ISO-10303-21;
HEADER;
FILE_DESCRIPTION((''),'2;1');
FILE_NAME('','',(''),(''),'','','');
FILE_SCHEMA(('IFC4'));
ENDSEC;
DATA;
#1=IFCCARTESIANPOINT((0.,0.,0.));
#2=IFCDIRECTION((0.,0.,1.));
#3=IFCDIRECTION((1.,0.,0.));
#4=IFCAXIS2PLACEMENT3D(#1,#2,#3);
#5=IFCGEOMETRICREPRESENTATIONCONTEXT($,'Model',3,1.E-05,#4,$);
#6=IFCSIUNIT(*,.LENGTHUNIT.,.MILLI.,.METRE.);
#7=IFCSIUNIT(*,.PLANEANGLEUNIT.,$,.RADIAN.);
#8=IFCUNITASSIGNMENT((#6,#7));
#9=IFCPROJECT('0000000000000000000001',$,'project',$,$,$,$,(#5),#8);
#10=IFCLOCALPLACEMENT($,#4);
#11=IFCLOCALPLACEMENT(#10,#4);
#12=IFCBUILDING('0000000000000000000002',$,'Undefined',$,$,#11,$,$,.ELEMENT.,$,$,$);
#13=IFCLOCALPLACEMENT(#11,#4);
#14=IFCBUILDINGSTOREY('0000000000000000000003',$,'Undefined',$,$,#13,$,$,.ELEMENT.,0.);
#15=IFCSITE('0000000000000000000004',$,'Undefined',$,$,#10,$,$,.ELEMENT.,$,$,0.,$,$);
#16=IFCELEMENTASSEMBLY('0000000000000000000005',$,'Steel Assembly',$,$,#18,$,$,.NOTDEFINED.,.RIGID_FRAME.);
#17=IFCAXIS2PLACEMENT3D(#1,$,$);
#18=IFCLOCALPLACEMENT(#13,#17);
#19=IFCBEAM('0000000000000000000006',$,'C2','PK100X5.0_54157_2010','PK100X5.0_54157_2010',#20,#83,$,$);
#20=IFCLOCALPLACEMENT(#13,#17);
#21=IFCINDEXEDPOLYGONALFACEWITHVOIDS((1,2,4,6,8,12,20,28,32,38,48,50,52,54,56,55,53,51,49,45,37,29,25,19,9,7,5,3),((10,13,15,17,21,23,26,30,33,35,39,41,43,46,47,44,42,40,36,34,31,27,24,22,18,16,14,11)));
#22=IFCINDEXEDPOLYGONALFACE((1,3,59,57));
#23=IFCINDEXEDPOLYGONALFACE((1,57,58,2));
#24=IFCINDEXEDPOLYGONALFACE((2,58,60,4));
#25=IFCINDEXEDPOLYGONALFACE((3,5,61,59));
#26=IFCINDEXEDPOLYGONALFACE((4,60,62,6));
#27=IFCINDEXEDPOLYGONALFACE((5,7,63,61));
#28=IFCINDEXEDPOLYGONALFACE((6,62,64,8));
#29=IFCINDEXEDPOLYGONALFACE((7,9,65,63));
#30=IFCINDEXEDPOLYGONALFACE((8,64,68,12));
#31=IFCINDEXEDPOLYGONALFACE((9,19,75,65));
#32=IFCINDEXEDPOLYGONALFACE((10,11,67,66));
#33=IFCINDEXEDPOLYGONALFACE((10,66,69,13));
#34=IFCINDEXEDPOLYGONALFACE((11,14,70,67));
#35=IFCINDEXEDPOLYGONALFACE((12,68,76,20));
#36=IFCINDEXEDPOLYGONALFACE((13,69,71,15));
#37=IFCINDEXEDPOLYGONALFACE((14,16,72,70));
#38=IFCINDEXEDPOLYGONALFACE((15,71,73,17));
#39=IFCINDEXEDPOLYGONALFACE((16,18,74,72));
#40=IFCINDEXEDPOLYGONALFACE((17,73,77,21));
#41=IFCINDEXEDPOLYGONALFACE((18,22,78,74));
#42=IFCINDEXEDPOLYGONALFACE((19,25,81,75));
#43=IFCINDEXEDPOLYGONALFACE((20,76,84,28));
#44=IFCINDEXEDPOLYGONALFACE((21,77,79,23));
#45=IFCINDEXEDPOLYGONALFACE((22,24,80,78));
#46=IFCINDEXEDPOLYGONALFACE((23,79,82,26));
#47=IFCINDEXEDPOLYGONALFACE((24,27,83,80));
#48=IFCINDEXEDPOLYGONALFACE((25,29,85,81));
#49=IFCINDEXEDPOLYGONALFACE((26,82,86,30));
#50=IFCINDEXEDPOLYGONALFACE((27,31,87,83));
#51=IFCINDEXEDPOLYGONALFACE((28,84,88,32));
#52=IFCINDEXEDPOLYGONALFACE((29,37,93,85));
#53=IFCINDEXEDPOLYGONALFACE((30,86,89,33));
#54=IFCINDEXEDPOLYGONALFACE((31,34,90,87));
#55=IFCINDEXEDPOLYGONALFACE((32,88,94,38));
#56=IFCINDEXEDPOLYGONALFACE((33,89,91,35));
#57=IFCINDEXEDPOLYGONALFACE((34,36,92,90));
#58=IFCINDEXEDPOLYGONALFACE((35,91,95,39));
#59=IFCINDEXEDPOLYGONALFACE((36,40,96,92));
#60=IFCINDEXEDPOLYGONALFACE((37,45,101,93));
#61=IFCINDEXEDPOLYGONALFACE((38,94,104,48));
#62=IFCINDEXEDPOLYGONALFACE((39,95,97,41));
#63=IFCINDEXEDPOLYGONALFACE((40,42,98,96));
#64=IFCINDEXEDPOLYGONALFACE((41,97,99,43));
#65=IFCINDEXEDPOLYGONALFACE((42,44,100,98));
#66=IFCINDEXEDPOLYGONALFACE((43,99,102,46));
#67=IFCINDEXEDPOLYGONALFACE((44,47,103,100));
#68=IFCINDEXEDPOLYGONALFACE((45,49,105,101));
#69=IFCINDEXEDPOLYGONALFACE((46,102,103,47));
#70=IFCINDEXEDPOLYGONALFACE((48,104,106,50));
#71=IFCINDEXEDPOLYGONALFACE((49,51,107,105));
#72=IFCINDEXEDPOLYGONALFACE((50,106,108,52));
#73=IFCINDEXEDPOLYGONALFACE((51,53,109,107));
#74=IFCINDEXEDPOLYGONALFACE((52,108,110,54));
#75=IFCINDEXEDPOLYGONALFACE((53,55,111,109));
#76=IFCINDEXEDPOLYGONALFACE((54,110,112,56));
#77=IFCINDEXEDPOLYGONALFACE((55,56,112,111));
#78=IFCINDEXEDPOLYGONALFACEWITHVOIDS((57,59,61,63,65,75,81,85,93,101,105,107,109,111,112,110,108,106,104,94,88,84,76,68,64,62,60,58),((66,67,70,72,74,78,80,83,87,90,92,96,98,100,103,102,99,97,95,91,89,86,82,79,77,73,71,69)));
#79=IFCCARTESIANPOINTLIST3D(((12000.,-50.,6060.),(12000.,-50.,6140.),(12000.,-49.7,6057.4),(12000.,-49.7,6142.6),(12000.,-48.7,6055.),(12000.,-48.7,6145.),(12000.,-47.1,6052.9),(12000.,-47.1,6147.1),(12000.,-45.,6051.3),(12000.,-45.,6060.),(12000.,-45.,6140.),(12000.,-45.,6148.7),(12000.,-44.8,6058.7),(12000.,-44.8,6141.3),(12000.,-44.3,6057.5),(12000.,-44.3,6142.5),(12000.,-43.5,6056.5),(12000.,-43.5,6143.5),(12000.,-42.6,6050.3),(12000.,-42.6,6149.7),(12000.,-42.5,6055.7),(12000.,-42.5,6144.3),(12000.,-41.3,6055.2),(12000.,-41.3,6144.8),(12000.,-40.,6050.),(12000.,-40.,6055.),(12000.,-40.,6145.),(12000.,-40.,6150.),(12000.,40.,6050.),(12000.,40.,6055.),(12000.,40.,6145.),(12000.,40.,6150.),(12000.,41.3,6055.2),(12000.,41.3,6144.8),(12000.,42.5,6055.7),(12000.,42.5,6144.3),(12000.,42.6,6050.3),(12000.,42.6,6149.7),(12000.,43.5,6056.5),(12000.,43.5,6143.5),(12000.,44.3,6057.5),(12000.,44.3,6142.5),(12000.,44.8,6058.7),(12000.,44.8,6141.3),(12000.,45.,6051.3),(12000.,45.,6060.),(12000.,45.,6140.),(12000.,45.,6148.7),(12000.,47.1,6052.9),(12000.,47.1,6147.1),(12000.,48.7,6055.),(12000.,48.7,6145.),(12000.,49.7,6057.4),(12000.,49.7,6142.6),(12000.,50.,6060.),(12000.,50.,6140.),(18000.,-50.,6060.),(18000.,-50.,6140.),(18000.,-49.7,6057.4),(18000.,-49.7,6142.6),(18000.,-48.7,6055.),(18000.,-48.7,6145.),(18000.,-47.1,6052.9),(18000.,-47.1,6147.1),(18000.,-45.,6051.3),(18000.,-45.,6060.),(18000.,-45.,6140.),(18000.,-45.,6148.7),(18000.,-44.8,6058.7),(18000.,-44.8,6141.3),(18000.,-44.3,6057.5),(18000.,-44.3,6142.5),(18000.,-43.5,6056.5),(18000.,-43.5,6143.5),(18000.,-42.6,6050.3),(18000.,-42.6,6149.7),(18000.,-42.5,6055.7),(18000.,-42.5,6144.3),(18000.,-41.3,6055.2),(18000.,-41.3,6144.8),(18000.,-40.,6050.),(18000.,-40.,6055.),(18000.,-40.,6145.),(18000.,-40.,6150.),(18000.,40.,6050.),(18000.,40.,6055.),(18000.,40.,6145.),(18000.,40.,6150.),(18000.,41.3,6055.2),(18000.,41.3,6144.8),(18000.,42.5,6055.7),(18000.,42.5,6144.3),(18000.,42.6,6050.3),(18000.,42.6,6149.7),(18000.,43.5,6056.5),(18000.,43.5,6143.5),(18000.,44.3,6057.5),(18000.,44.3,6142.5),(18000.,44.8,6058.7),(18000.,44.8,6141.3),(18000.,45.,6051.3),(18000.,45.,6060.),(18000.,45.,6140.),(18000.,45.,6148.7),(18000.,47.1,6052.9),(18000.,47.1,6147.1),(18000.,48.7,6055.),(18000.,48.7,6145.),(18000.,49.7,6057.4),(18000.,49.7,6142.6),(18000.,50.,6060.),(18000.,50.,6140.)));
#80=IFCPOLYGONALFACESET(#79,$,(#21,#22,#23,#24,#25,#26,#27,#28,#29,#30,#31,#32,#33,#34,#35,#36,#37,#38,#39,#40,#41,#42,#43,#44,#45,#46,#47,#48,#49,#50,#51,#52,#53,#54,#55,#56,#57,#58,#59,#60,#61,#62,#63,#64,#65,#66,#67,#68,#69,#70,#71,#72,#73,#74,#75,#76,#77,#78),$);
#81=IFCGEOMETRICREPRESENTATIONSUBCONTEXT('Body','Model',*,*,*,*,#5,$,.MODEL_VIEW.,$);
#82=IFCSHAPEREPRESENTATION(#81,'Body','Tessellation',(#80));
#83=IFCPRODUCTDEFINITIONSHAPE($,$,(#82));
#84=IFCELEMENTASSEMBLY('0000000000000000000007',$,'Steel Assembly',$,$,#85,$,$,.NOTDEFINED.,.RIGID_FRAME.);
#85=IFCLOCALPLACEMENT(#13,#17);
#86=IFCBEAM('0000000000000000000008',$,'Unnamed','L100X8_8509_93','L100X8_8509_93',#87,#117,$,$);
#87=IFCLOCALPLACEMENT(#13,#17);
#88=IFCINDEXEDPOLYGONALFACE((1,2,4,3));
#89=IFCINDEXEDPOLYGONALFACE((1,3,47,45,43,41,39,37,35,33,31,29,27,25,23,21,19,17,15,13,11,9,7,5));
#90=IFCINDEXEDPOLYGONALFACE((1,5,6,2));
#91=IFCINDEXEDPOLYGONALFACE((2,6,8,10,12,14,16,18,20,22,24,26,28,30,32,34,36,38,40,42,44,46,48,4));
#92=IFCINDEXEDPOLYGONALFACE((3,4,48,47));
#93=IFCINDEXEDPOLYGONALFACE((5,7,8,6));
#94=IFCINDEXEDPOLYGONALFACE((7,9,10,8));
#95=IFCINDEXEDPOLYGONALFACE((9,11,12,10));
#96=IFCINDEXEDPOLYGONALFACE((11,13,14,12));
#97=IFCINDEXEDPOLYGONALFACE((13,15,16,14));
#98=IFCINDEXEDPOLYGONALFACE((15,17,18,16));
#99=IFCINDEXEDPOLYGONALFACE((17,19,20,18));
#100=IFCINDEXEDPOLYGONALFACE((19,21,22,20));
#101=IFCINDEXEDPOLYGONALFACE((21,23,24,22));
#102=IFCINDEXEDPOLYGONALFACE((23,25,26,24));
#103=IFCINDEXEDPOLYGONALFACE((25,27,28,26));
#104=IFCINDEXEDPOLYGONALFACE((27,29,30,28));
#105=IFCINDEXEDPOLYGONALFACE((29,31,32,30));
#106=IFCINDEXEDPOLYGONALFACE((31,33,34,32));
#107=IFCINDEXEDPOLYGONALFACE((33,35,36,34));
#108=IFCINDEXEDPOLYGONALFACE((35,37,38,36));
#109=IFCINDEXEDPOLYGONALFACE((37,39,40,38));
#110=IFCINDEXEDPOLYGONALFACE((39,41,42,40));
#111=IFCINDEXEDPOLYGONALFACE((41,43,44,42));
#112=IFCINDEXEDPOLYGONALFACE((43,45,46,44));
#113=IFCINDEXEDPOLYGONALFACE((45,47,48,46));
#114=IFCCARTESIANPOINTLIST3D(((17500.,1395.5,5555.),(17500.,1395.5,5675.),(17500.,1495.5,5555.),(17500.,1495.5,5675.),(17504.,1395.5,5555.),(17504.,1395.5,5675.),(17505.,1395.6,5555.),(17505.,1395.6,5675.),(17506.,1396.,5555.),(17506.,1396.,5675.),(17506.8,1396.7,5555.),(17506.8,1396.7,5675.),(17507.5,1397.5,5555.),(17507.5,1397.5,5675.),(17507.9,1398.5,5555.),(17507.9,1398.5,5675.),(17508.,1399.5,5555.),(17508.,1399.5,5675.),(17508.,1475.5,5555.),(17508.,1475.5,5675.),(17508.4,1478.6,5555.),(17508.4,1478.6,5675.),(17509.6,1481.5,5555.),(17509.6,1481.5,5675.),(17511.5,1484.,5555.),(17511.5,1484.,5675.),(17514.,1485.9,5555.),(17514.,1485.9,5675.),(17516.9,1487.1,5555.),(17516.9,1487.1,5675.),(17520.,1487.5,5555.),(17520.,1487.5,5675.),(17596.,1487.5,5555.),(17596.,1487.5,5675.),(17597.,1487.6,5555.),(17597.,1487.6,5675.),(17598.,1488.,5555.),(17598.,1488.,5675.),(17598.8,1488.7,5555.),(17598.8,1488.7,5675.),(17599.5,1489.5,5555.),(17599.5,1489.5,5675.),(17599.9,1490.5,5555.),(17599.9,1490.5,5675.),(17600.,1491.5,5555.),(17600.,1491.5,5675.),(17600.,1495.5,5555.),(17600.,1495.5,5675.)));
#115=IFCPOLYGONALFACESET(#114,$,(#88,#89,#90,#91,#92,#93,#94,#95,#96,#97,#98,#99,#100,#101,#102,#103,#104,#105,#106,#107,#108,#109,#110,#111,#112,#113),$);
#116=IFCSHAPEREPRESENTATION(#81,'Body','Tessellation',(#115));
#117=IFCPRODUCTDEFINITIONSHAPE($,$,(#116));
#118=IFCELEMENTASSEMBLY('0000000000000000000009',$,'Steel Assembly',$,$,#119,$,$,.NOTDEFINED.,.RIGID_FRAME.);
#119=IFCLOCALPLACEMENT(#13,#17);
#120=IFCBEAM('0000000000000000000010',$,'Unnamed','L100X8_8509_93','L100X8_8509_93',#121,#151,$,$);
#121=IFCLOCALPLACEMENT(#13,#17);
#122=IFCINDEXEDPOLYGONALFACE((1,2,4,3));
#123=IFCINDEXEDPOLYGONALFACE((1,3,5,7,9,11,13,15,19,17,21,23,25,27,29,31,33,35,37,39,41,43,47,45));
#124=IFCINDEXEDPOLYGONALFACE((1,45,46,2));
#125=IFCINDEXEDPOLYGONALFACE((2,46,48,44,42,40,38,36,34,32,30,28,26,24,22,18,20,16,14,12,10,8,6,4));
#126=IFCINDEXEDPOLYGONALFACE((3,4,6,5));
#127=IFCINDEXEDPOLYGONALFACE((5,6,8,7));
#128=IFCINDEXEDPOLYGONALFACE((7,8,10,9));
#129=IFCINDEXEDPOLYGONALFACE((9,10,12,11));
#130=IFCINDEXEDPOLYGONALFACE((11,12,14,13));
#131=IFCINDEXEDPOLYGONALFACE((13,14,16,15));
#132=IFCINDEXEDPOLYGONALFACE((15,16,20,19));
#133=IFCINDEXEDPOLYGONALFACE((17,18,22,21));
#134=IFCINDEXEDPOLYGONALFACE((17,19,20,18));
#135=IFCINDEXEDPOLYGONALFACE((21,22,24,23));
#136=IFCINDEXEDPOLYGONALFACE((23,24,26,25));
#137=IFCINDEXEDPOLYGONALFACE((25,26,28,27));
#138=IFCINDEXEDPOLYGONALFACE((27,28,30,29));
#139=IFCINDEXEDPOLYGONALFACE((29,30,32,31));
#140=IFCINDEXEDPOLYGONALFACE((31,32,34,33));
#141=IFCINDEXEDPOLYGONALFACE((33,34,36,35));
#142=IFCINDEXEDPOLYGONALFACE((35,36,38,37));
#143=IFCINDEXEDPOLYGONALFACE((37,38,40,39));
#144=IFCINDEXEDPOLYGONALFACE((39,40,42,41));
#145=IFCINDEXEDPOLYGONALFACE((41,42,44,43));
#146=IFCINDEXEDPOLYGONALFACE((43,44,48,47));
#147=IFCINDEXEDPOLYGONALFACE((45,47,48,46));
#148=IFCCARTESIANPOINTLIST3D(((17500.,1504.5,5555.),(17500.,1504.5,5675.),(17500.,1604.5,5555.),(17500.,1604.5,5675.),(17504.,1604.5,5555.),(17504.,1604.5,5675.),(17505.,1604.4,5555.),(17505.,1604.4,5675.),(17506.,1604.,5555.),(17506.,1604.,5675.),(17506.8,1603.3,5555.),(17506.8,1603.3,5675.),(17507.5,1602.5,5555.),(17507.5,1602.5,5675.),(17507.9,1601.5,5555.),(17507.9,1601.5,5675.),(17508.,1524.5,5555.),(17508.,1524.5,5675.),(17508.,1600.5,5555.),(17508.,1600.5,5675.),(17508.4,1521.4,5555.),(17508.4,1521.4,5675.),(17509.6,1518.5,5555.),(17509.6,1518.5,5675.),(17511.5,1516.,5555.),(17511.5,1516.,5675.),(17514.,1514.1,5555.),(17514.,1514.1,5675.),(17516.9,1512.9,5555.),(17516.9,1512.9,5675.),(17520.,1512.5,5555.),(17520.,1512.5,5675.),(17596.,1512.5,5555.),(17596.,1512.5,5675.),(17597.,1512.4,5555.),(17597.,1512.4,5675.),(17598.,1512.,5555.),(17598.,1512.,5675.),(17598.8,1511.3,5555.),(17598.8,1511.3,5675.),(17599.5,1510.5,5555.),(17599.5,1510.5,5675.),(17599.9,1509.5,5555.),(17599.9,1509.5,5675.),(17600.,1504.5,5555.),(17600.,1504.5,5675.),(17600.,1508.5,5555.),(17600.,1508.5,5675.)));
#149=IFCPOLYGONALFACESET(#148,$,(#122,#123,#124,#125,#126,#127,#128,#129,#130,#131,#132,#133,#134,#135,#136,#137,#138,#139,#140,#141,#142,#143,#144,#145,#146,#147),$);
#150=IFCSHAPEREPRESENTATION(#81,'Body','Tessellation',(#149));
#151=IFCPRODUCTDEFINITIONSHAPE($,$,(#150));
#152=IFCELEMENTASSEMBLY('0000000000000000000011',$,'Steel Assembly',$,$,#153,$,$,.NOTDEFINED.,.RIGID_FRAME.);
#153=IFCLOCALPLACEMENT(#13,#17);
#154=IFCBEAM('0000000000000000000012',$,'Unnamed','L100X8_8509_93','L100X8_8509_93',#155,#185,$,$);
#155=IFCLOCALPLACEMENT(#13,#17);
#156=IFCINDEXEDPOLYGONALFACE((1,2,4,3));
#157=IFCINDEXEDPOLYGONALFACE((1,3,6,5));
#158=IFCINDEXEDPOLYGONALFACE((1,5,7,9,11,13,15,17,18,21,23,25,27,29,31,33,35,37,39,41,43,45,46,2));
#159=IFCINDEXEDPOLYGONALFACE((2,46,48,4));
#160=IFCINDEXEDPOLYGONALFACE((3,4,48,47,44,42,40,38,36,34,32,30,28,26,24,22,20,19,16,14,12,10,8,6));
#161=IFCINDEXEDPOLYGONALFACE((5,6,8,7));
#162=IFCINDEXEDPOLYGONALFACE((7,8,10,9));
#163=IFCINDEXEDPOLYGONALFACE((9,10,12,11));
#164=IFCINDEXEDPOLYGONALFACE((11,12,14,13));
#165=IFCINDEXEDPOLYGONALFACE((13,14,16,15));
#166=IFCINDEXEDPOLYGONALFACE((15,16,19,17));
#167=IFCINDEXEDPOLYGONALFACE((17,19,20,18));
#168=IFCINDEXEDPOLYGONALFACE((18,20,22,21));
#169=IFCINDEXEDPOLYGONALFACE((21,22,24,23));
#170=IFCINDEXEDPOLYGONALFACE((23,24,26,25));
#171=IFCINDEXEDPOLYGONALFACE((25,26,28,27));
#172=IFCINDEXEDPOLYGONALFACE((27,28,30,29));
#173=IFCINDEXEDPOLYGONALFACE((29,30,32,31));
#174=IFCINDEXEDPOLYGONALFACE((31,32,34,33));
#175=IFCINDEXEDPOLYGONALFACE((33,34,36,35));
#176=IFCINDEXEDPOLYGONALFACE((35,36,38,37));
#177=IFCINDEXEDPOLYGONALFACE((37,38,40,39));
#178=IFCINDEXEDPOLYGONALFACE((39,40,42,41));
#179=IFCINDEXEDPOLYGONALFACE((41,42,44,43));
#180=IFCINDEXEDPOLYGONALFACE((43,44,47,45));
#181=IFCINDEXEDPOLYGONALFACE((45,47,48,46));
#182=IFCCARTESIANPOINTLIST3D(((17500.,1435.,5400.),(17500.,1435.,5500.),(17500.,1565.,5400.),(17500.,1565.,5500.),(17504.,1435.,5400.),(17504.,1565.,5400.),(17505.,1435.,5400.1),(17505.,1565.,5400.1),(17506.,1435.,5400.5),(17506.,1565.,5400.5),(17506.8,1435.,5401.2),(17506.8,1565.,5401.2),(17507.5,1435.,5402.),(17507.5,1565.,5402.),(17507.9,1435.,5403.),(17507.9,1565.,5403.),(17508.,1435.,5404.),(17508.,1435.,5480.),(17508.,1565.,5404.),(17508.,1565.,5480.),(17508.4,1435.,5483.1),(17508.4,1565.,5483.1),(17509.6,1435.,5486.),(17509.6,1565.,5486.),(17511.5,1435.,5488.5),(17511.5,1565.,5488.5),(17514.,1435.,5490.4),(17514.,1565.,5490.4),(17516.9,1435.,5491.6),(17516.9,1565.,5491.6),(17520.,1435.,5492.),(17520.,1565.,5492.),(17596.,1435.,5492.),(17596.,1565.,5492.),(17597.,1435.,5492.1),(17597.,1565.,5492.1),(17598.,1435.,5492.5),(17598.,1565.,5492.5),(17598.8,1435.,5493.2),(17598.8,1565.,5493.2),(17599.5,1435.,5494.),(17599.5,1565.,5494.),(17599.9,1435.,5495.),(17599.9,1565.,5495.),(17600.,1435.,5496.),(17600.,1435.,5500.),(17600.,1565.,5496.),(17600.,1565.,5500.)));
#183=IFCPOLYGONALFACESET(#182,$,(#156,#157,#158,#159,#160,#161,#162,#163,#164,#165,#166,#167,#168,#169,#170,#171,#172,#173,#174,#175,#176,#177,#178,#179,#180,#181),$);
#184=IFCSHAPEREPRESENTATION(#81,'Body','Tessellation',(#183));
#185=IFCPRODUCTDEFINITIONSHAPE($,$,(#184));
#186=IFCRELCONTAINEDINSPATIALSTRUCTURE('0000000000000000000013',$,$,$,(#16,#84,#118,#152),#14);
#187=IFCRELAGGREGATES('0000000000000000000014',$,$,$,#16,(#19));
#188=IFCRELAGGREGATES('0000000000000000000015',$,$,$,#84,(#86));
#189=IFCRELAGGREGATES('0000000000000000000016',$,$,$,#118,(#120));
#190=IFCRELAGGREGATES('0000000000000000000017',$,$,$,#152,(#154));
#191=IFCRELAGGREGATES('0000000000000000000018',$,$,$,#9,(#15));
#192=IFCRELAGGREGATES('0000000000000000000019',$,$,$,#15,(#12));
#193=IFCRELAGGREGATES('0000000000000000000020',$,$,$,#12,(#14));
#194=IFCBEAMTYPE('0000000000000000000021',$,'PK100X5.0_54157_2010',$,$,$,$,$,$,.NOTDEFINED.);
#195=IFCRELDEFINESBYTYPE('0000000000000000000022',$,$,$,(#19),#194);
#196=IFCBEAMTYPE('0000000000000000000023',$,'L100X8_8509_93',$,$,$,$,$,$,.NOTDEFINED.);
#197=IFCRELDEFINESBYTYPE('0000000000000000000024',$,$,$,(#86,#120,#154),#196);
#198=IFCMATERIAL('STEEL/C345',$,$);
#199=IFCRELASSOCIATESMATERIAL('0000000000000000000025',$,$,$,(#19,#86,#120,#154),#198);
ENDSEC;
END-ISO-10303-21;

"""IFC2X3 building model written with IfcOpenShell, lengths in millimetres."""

from ifc_helpers import new_model, si_unit, frame, origin_with_axes, origin_2d_with_axis, place, context, subcontext, project, spatial, hollow_rectangle, l_section, extrude, material, type_object, element, aggregate, save


model = new_model("IFC2X3")

# Units and contexts
model_context = context("Model", 3, precision=1e-05, world=origin_with_axes())
body_context = subcontext(model_context, "Body", "Model", "MODEL_VIEW")
ifc_project = project(units=[si_unit("LENGTHUNIT", "METRE", prefix="MILLI"), si_unit("PLANEANGLEUNIT", "RADIAN")], contexts=[model_context])

# Site, building, storey
site_placement = place(None, origin_with_axes())
site = spatial("IfcSite", under=ifc_project, at=site_placement, Name="Undefined", CompositionType="ELEMENT", RefElevation=0.0)
building_placement = place(site_placement, origin_with_axes())
building = spatial("IfcBuilding", under=site, at=building_placement, Name="Undefined", CompositionType="ELEMENT")
storey_placement = place(building_placement, origin_with_axes())
storey = spatial("IfcBuildingStorey", under=building, at=storey_placement, Name="Undefined", CompositionType="ELEMENT", Elevation=0.0)

# Element assemblies, beams
assembly_1_placement = place(storey_placement, origin_with_axes())
assembly_1 = element("IfcElementAssembly", 1, at=assembly_1_placement, inside=storey, Name="Steel Assembly", AssemblyPlace="NOTDEFINED", PredefinedType="RIGID_FRAME")
ifc_material = material(Name="STEEL/C345")
beam_type_1 = type_object("IfcBeamType", Name="PK100X5.0_54157_2010", PredefinedType="NOTDEFINED")
beam_1_placement = place(assembly_1_placement, frame((18000.0, 0.0, 6100.0), z_axis=(0.0, 0.0, 1.0), x_axis=(-1.0, 0.0, 0.0)))
beam_1 = element("IfcBeam", 2, at=beam_1_placement, type_object=beam_type_1, material=ifc_material, Name="C2", Description="PK100X5.0_54157_2010", ObjectType="PK100X5.0_54157_2010", context=body_context, shape_type="SweptSolid", body=[
    extrude(hollow_rectangle(XDim=100.0, YDim=100.0, WallThickness=5.0, InnerFilletRadius=5.0, OuterFilletRadius=10.0, at=origin_2d_with_axis()), frame((6000.0, 0.0, 0.0), z_axis=(-1.0, 0.0, 0.0), x_axis=(0.0, -1.0, 0.0)), (0.0, 0.0, 1.0), 6000.0),
])
aggregate(assembly_1, [beam_1])
assembly_2_placement = place(storey_placement, origin_with_axes())
assembly_2 = element("IfcElementAssembly", 3, at=assembly_2_placement, inside=storey, Name="Steel Assembly", AssemblyPlace="NOTDEFINED", PredefinedType="RIGID_FRAME")
beam_type_2 = type_object("IfcBeamType", Name="L100X8_8509_93", PredefinedType="NOTDEFINED")
beam_2_placement = place(assembly_2_placement, frame((17550.0, 1445.5, 5675.0), z_axis=(1.0, 0.0, 0.0), x_axis=(0.0, 0.0, -1.0)))
beam_2 = element("IfcBeam", 4, at=beam_2_placement, type_object=beam_type_2, material=ifc_material, Name="Unnamed", Description="L100X8_8509_93", ObjectType="L100X8_8509_93", context=body_context, shape_type="SweptSolid", body=[
    extrude(l_section(Depth=100.0, Width=100.0, Thickness=8.0, FilletRadius=12.0, EdgeRadius=4.0, at=origin_2d_with_axis()), frame((120.0, 0.0, 0.0), z_axis=(-1.0, 0.0, 0.0), x_axis=(0.0, -1.0, 0.0)), (0.0, 0.0, 1.0), 120.0),
])
aggregate(assembly_2, [beam_2])
assembly_3_placement = place(storey_placement, origin_with_axes())
assembly_3 = element("IfcElementAssembly", 5, at=assembly_3_placement, inside=storey, Name="Steel Assembly", AssemblyPlace="NOTDEFINED", PredefinedType="RIGID_FRAME")
beam_3_placement = place(assembly_3_placement, frame((17550.0, 1554.5, 5675.0), z_axis=(0.0, 1.0, 0.0), x_axis=(0.0, 0.0, -1.0)))
beam_3 = element("IfcBeam", 6, at=beam_3_placement, type_object=beam_type_2, material=ifc_material, Name="Unnamed", Description="L100X8_8509_93", ObjectType="L100X8_8509_93", context=body_context, shape_type="SweptSolid", body=[
    extrude(l_section(Depth=100.0, Width=100.0, Thickness=8.0, FilletRadius=12.0, EdgeRadius=4.0, at=origin_2d_with_axis()), frame((120.0, 0.0, 0.0), z_axis=(-1.0, 0.0, 0.0), x_axis=(0.0, -1.0, 0.0)), (0.0, 0.0, 1.0), 120.0),
])
aggregate(assembly_3, [beam_3])
assembly_4_placement = place(storey_placement, origin_with_axes())
assembly_4 = element("IfcElementAssembly", 7, at=assembly_4_placement, inside=storey, Name="Steel Assembly", AssemblyPlace="NOTDEFINED", PredefinedType="RIGID_FRAME")
beam_4_placement = place(assembly_4_placement, frame((17550.0, 1435.0, 5450.0), z_axis=(1.0, 0.0, 0.0), x_axis=(0.0, 1.0, 0.0)))
beam_4 = element("IfcBeam", 8, at=beam_4_placement, type_object=beam_type_2, material=ifc_material, Name="Unnamed", Description="L100X8_8509_93", ObjectType="L100X8_8509_93", context=body_context, shape_type="SweptSolid", body=[
    extrude(l_section(Depth=100.0, Width=100.0, Thickness=8.0, FilletRadius=12.0, EdgeRadius=4.0, at=origin_2d_with_axis()), frame((130.0, 0.0, 0.0), z_axis=(-1.0, 0.0, 0.0), x_axis=(0.0, -1.0, 0.0)), (0.0, 0.0, 1.0), 130.0),
])
aggregate(assembly_4, [beam_4])

save(model, "model.ifc")
